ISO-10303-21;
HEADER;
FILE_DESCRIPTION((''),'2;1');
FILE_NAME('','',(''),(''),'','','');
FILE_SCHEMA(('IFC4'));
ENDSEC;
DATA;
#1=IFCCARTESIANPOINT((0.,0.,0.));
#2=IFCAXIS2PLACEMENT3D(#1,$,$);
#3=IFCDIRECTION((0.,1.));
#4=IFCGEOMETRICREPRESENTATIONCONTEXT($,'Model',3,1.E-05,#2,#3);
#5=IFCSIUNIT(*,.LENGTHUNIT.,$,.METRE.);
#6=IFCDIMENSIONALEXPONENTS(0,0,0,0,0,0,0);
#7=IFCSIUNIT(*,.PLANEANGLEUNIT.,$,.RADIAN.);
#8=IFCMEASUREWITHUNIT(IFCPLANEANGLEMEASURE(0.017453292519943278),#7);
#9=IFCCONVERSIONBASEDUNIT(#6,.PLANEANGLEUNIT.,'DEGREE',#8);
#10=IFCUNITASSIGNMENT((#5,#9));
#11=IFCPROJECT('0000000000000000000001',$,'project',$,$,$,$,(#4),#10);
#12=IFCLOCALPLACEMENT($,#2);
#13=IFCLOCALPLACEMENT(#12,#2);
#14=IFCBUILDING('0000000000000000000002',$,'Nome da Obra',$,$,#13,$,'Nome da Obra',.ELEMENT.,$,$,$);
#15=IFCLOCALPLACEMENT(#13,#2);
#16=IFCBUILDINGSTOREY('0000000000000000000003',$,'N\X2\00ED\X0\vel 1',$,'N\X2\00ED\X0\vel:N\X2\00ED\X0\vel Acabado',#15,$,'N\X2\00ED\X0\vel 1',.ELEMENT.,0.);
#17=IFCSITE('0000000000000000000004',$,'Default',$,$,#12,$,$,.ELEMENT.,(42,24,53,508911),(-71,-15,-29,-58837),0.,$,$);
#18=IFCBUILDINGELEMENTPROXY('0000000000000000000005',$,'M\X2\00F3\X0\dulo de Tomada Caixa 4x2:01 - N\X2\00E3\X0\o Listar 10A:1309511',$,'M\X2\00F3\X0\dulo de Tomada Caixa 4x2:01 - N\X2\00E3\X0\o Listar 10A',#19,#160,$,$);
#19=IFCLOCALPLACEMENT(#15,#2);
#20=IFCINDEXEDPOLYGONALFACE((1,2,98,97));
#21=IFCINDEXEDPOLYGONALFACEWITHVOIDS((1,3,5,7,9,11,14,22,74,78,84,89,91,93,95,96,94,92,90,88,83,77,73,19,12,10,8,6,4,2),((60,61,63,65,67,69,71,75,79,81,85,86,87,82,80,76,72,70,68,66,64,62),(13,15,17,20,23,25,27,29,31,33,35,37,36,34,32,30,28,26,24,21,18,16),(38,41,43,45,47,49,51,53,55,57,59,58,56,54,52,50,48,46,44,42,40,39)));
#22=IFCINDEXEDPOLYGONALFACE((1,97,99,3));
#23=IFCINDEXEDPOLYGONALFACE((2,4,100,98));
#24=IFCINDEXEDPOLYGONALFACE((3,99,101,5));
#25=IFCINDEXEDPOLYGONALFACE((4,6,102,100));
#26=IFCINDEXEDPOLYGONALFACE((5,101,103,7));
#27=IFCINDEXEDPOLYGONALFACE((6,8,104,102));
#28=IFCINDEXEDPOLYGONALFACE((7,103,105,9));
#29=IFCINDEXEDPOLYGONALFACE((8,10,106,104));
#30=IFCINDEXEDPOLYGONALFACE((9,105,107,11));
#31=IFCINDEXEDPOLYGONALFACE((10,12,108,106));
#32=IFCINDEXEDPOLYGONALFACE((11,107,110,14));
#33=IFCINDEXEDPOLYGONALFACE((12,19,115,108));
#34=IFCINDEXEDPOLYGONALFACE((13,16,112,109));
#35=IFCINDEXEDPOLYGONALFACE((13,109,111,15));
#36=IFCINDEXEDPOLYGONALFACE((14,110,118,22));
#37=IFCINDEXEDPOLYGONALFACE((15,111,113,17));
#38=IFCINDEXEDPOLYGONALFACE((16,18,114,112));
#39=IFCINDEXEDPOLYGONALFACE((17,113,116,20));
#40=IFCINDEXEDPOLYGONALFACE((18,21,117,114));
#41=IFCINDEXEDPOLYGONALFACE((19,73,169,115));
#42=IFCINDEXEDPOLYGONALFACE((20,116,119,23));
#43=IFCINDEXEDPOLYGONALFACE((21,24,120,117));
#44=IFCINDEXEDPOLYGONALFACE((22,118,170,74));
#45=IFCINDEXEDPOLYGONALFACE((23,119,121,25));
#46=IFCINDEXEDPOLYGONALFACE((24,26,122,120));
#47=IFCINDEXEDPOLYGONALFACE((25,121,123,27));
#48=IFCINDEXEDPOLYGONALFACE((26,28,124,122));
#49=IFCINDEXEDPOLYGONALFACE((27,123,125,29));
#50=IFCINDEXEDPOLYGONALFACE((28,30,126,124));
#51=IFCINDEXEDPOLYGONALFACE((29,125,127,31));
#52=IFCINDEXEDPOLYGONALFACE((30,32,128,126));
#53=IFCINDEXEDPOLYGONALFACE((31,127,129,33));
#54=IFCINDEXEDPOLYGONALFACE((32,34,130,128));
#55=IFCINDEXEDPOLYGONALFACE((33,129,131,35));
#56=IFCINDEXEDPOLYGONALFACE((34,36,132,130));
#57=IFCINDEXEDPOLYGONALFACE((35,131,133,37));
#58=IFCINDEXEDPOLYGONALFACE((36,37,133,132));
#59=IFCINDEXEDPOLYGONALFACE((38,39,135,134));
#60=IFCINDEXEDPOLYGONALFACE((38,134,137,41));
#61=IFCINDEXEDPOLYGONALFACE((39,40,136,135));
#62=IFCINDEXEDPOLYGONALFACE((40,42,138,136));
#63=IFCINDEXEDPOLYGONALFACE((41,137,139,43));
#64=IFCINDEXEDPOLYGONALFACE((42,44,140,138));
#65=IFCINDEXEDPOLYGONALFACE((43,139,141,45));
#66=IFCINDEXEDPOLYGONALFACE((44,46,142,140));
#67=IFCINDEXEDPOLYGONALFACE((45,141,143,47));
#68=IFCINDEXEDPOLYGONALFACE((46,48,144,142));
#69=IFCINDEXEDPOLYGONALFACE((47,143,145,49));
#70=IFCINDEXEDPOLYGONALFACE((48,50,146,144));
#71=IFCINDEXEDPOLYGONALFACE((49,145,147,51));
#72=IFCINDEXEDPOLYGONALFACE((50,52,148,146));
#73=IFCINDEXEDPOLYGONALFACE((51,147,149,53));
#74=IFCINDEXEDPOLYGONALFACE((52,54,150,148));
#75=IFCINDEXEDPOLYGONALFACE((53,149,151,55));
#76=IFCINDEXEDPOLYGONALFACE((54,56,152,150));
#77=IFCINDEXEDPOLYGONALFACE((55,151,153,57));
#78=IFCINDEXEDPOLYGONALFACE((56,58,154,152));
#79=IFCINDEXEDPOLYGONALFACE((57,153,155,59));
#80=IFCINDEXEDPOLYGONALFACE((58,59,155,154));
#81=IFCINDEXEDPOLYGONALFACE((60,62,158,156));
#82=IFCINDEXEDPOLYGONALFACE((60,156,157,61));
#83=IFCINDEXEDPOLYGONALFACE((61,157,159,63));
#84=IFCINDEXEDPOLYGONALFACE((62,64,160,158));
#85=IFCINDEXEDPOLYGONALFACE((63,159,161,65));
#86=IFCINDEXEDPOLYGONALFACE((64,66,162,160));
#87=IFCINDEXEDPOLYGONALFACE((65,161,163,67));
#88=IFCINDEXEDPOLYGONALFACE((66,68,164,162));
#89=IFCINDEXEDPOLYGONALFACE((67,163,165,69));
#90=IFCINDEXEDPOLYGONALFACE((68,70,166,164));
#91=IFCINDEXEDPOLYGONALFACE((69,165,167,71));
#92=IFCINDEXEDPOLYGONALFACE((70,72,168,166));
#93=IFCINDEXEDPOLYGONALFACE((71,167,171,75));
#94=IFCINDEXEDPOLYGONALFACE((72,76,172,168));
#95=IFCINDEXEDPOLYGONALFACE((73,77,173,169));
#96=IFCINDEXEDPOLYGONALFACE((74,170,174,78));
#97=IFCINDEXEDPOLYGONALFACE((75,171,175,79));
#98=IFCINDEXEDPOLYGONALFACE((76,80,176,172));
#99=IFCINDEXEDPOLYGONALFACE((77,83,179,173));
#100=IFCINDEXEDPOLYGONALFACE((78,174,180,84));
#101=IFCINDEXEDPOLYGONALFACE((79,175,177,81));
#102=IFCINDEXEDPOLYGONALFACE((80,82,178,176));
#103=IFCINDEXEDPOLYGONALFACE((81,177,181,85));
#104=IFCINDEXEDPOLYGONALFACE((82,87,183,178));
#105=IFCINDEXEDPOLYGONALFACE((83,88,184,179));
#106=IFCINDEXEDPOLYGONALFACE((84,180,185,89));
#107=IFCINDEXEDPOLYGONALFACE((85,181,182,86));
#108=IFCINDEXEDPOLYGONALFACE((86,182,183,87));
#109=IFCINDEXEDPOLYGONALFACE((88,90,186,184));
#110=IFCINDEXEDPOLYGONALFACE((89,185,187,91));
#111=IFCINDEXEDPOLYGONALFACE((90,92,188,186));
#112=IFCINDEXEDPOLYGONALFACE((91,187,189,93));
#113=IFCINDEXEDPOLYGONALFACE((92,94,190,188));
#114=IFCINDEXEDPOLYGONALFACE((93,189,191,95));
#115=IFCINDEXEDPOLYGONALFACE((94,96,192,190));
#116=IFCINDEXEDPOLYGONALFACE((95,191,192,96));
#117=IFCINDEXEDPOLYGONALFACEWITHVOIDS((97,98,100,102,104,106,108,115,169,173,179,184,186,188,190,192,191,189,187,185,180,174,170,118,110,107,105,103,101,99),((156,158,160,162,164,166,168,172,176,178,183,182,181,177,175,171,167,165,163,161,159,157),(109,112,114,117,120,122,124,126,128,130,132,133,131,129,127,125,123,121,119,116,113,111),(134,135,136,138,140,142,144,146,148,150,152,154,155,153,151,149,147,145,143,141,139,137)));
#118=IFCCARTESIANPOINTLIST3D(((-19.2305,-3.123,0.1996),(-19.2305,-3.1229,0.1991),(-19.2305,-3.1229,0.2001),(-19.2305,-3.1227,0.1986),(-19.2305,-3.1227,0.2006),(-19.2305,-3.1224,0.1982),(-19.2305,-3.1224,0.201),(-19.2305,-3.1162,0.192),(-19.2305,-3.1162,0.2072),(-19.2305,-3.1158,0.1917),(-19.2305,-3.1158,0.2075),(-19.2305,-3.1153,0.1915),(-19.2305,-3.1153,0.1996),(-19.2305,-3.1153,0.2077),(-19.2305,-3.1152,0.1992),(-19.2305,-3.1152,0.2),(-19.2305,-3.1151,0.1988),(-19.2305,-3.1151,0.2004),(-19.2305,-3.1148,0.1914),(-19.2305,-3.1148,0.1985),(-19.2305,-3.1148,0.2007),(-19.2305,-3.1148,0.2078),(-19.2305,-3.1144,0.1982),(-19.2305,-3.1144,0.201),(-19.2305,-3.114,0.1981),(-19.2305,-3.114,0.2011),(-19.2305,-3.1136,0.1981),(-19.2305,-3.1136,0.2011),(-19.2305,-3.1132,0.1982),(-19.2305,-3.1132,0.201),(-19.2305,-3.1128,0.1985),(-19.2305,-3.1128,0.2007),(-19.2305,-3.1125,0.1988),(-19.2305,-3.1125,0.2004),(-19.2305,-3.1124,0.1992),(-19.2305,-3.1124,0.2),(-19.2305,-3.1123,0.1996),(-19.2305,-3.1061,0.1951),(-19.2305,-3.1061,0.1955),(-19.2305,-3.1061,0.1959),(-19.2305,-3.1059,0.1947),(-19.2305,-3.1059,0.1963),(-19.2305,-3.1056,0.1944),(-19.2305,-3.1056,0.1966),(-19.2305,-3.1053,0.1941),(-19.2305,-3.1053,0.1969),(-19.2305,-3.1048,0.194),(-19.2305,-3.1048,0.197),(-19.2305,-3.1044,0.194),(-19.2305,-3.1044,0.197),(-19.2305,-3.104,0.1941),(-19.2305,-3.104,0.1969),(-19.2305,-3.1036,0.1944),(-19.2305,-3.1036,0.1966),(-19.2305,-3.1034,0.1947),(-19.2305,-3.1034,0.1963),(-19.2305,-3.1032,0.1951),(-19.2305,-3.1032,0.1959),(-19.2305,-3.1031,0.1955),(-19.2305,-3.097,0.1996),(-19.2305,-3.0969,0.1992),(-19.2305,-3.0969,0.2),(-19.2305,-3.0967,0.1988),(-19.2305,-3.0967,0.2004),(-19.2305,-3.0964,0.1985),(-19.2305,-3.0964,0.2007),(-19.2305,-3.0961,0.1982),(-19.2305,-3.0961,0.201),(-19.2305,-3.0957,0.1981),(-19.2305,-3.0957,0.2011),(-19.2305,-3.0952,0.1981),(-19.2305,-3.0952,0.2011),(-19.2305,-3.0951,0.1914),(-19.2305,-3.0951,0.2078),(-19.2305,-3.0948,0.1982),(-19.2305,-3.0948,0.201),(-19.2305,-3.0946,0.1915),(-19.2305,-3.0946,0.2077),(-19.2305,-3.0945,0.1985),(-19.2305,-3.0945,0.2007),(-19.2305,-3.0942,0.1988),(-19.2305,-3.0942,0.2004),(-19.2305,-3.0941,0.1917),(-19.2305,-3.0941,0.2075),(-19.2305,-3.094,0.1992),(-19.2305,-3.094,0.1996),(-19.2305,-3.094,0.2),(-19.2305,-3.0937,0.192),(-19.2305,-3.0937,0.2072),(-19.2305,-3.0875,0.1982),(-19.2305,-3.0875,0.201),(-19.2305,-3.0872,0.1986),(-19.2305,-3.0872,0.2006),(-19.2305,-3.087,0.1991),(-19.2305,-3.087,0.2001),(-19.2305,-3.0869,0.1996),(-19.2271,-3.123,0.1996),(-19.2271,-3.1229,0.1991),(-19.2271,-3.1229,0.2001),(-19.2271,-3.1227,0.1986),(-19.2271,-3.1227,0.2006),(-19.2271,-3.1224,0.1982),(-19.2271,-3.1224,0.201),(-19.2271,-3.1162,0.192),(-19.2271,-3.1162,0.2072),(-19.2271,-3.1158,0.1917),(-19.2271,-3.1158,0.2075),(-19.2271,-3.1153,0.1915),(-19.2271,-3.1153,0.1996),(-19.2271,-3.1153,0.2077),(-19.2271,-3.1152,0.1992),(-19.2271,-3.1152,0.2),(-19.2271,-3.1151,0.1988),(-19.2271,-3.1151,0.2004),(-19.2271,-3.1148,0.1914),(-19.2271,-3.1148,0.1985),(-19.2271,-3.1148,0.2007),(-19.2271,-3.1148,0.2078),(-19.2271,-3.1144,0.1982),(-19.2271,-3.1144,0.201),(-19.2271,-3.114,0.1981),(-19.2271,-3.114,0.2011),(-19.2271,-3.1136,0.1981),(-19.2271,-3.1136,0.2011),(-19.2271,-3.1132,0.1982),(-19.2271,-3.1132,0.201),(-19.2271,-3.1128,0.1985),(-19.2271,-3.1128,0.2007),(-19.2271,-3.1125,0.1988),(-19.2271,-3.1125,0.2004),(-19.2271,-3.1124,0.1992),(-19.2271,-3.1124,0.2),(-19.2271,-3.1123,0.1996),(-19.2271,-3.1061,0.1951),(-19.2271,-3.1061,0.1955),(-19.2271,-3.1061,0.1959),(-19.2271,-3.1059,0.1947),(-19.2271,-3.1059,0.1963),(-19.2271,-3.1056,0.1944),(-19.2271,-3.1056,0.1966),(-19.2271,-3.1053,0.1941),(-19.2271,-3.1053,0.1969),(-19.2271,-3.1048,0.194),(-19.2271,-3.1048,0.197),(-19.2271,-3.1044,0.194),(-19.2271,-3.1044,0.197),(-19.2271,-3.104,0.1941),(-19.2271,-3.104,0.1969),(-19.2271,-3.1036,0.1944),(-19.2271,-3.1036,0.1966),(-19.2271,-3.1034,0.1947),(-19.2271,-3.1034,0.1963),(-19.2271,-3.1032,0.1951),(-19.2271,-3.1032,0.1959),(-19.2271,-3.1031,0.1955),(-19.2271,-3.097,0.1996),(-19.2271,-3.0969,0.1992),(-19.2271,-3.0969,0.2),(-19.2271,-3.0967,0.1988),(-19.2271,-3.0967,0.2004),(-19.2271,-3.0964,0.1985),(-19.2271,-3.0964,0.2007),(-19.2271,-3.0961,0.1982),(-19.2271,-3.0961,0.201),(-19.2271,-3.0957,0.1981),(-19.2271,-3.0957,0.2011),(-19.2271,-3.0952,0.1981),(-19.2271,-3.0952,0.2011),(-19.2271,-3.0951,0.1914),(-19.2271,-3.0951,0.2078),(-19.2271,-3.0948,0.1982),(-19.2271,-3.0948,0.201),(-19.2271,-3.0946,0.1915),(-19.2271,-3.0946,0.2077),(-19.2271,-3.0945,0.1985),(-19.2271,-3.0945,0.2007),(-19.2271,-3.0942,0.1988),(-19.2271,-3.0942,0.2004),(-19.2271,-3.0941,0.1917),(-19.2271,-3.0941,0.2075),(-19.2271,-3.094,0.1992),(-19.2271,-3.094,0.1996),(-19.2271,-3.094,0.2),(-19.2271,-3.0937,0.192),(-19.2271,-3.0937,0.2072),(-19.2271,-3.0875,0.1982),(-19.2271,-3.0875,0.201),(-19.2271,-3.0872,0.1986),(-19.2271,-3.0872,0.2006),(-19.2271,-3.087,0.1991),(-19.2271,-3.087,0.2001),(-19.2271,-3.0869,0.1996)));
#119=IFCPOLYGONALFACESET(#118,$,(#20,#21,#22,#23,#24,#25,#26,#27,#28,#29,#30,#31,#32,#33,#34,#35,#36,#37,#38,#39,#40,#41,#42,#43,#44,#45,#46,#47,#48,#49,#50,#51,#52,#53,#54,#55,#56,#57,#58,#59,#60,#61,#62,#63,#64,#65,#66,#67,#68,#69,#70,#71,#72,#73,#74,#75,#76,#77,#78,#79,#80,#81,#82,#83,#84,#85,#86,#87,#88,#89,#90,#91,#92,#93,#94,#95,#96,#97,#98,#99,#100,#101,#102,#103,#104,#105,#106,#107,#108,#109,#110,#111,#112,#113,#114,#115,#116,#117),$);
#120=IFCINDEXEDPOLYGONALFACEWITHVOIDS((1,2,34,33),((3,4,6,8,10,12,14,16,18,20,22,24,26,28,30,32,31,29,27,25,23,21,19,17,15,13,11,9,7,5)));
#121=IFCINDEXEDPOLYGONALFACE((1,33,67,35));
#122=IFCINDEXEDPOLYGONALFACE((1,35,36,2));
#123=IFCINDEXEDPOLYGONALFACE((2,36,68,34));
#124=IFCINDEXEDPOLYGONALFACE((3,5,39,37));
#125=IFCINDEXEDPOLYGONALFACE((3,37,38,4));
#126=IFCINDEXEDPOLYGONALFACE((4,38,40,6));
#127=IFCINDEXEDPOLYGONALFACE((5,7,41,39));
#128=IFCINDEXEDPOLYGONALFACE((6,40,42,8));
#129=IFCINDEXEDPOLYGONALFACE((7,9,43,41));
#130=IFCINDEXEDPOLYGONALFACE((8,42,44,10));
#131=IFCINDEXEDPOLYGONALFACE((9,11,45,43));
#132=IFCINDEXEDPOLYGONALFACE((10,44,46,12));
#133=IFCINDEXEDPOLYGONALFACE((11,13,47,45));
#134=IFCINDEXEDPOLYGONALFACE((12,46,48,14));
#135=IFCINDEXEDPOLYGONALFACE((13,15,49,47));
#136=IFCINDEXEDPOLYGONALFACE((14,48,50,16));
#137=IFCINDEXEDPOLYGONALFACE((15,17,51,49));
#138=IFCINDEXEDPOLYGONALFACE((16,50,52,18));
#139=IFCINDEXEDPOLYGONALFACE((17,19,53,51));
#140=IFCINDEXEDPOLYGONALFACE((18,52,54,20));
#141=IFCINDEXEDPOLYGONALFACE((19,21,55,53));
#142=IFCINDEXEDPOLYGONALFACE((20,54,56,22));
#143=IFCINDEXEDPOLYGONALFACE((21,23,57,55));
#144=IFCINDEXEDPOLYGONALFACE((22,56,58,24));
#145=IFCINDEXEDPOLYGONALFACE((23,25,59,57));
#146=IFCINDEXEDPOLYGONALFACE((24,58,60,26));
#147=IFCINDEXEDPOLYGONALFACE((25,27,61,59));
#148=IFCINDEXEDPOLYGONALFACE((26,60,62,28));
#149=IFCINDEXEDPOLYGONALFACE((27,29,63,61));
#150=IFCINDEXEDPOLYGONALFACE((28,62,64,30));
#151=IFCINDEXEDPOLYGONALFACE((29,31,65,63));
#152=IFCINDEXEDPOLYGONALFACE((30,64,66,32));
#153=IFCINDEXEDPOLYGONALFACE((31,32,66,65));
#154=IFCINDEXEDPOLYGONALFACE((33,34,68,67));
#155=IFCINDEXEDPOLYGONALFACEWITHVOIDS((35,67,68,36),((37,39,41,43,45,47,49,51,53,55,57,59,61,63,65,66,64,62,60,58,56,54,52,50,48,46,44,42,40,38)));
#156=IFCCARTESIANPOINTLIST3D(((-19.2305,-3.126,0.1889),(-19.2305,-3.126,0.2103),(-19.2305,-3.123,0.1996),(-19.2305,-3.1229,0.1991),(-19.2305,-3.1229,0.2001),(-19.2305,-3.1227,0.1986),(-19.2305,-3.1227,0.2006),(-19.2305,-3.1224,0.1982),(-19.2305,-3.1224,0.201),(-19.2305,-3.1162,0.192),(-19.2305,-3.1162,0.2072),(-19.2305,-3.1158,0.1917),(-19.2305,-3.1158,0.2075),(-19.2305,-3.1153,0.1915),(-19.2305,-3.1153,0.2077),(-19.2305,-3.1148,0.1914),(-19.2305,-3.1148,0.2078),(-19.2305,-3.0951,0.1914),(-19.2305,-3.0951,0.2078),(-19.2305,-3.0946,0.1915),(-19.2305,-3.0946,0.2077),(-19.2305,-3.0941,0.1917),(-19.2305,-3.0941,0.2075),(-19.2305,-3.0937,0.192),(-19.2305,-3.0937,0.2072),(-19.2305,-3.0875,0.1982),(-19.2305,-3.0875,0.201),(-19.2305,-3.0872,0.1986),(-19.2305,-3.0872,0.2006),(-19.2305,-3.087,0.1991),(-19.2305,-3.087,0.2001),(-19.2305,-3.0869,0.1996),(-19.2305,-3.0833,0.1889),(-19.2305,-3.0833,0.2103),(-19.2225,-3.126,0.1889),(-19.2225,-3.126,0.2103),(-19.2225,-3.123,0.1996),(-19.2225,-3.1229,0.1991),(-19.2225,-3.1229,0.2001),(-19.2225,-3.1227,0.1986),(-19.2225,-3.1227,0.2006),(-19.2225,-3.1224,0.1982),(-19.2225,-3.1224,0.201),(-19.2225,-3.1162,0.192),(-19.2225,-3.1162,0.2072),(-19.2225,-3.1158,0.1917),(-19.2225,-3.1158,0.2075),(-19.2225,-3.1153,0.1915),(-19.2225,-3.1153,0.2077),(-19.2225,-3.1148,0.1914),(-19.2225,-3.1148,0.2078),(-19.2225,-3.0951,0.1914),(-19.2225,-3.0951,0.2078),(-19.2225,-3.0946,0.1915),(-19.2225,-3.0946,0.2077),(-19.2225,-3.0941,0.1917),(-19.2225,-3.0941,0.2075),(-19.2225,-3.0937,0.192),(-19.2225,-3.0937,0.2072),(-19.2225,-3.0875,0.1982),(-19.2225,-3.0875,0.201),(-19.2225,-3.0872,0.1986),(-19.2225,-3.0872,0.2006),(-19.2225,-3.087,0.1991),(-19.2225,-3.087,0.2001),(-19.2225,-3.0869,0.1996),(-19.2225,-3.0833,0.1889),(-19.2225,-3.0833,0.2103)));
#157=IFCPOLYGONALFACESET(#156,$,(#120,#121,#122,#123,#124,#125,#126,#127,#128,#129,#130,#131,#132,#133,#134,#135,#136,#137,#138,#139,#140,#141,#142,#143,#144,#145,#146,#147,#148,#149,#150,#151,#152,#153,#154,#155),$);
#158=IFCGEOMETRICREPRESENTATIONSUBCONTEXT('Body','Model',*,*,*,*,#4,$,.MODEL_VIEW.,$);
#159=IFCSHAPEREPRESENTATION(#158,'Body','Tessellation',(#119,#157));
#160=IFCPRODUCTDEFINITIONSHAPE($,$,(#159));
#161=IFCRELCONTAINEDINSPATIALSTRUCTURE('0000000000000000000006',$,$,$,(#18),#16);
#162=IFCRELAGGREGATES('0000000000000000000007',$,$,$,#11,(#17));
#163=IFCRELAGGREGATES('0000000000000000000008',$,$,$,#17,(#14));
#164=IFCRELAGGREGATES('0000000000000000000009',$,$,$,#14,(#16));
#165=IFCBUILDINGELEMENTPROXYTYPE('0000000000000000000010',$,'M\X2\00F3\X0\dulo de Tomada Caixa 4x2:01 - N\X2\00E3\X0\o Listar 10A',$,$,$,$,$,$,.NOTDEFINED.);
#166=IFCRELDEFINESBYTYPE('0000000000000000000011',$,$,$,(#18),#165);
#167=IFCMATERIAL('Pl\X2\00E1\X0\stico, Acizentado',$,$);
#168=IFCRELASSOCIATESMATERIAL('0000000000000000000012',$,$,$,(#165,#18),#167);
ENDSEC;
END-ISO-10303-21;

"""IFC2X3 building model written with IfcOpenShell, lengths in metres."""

from ifc_helpers import new_model, entity, si_unit, converted_unit, direction, frame, frame_2d, origin, place, context, subcontext, project, spatial, polyline, circle_curve, parameter, trimmed, segment, composite_curve, outline, extrude, source, transform, mapped, material, type_object, type_shapes, element, save


model = new_model("IFC2X3")

# Units and contexts
model_context = context("Model", 3, precision=1e-05, world=origin(), true_north=direction((0.0, 1.0)))
body_context = subcontext(model_context, "Body", "Model", "MODEL_VIEW")
ifc_project = project(units=[si_unit("LENGTHUNIT", "METRE"), converted_unit("PLANEANGLEUNIT", "DEGREE", entity("IfcPlaneAngleMeasure", 0.017453292519943278), si_unit("PLANEANGLEUNIT", "RADIAN"), dimensions=[0, 0, 0, 0, 0, 0, 0])], contexts=[model_context])

# Site, building, storey
site_placement = place(None, origin())
site = spatial("IfcSite", under=ifc_project, at=site_placement, Name="Default", CompositionType="ELEMENT", RefLatitude=(42, 24, 53, 508911), RefLongitude=(-71, -15, -29, -58837), RefElevation=0.0)
building_placement = place(site_placement, origin())
building = spatial("IfcBuilding", under=site, at=building_placement, Name="Nome da Obra", LongName="Nome da Obra", CompositionType="ELEMENT")
storey_placement = place(building_placement, origin())
storey = spatial("IfcBuildingStorey", under=building, at=storey_placement, Name="Nível 1", ObjectType="Nível:Nível Acabado", LongName="Nível 1", CompositionType="ELEMENT", Elevation=0.0)

# Building element proxy
ifc_material_1 = material(Name="Plástico, Acizentado")
building_element_proxy_type_1 = type_object("IfcBuildingElementProxyType", Name="Módulo de Tomada Caixa 4x2:01 - Não Listar 10A", PredefinedType="NOTDEFINED", material=ifc_material_1)
shared_shape_1 = source(origin(), body_context, "Body", "SweptSolid", [
    extrude(outline(composite_curve([segment(polyline([(-0.0098, -0.0082), (0.0098, -0.0082)]), True, "CONTINUOUS"), segment(trimmed(circle_curve(frame_2d((0.0098, -0.0062), x_axis=(1.0, 0.0)), 0.002), [parameter(270.0)], [parameter(315.0)], True, "PARAMETER"), True, "CONTINUOUS"), segment(polyline([(0.0112, -0.0076), (0.0174, -0.0014)]), True, "CONTINUOUS"), segment(trimmed(circle_curve(frame_2d((0.016, 0.0), x_axis=(1.0, 0.0)), 0.002), [parameter(315.0)], [parameter(45.0)], True, "PARAMETER"), True, "CONTINUOUS"), segment(polyline([(0.0174, 0.0014), (0.0112, 0.0076)]), True, "CONTINUOUS"), segment(trimmed(circle_curve(frame_2d((0.0098, 0.0062), x_axis=(1.0, 0.0)), 0.002), [parameter(45.0)], [parameter(90.0)], True, "PARAMETER"), True, "CONTINUOUS"), segment(polyline([(0.0098, 0.0082), (-0.0098, 0.0082)]), True, "CONTINUOUS"), segment(trimmed(circle_curve(frame_2d((-0.0098, 0.0062), x_axis=(1.0, 0.0)), 0.002), [parameter(90.0)], [parameter(135.0)], True, "PARAMETER"), True, "CONTINUOUS"), segment(polyline([(-0.0112, 0.0076), (-0.0174, 0.0014)]), True, "CONTINUOUS"), segment(trimmed(circle_curve(frame_2d((-0.016, 0.0), x_axis=(1.0, 0.0)), 0.002), [parameter(135.0)], [parameter(225.0)], True, "PARAMETER"), True, "CONTINUOUS"), segment(polyline([(-0.0174, -0.0014), (-0.0112, -0.0076)]), True, "CONTINUOUS"), segment(trimmed(circle_curve(frame_2d((-0.0098, -0.0062), x_axis=(1.0, 0.0)), 0.002), [parameter(225.0)], [parameter(270.0)], True, "PARAMETER"), True, "CONTINUOUS")], self_intersect=False), holes=[composite_curve([segment(trimmed(circle_curve(frame_2d((0.0089, 0.0), x_axis=(1.0, 0.0)), 0.0015), [parameter(0.0)], [parameter(180.0)], True, "PARAMETER"), False, "CONTINUOUS"), segment(trimmed(circle_curve(frame_2d((0.0089, 0.0), x_axis=(1.0, 0.0)), 0.0015), [parameter(180.0)], [parameter(0.0)], True, "PARAMETER"), False, "CONTINUOUS")], self_intersect=False), composite_curve([segment(trimmed(circle_curve(frame_2d((-0.0003, 0.0041), x_axis=(1.0, 0.0)), 0.0015), [parameter(0.0)], [parameter(180.0)], True, "PARAMETER"), False, "CONTINUOUS"), segment(trimmed(circle_curve(frame_2d((-0.0003, 0.0041), x_axis=(1.0, 0.0)), 0.0015), [parameter(180.0)], [parameter(0.0)], True, "PARAMETER"), False, "CONTINUOUS")], self_intersect=False), composite_curve([segment(trimmed(circle_curve(frame_2d((-0.0095, 0.0), x_axis=(1.0, 0.0)), 0.0015), [parameter(0.0)], [parameter(180.0)], True, "PARAMETER"), False, "CONTINUOUS"), segment(trimmed(circle_curve(frame_2d((-0.0095, 0.0), x_axis=(1.0, 0.0)), 0.0015), [parameter(180.0)], [parameter(0.0)], True, "PARAMETER"), False, "CONTINUOUS")], self_intersect=False)]), frame((0.0003, 0.0, 0.125), z_axis=(0.0, 1.0, 0.0), x_axis=(1.0, 0.0, 0.0)), (0.0, 0.0, 1.0), 0.0034),
    extrude(outline(polyline([(-0.0214, -0.0107), (0.0214, -0.0107), (0.0214, 0.0107), (-0.0214, 0.0107), (-0.0214, -0.0107)]), holes=[composite_curve([segment(polyline([(0.0101, -0.0082), (-0.0095, -0.0082)]), True, "CONTINUOUS"), segment(trimmed(circle_curve(frame_2d((-0.0095, -0.0062), x_axis=(1.0, 0.0)), 0.002), [parameter(225.0)], [parameter(270.0)], True, "PARAMETER"), False, "CONTINUOUS"), segment(polyline([(-0.0109, -0.0076), (-0.0171, -0.0014)]), True, "CONTINUOUS"), segment(trimmed(circle_curve(frame_2d((-0.0157, 0.0), x_axis=(1.0, 0.0)), 0.002), [parameter(135.0)], [parameter(225.0)], True, "PARAMETER"), False, "CONTINUOUS"), segment(polyline([(-0.0171, 0.0014), (-0.0109, 0.0076)]), True, "CONTINUOUS"), segment(trimmed(circle_curve(frame_2d((-0.0095, 0.0062), x_axis=(1.0, 0.0)), 0.002), [parameter(90.0)], [parameter(135.0)], True, "PARAMETER"), False, "CONTINUOUS"), segment(polyline([(-0.0095, 0.0082), (0.0101, 0.0082)]), True, "CONTINUOUS"), segment(trimmed(circle_curve(frame_2d((0.0101, 0.0062), x_axis=(1.0, 0.0)), 0.002), [parameter(45.0)], [parameter(90.0)], True, "PARAMETER"), False, "CONTINUOUS"), segment(polyline([(0.0115, 0.0076), (0.0177, 0.0014)]), True, "CONTINUOUS"), segment(trimmed(circle_curve(frame_2d((0.0163, 0.0), x_axis=(1.0, 0.0)), 0.002), [parameter(315.0)], [parameter(45.0)], True, "PARAMETER"), False, "CONTINUOUS"), segment(polyline([(0.0177, -0.0014), (0.0115, -0.0076)]), True, "CONTINUOUS"), segment(trimmed(circle_curve(frame_2d((0.0101, -0.0062), x_axis=(1.0, 0.0)), 0.002), [parameter(270.0)], [parameter(315.0)], True, "PARAMETER"), False, "CONTINUOUS")], self_intersect=False)]), frame((0.0, 0.0, 0.125), z_axis=(0.0, 1.0, 0.0), x_axis=(1.0, 0.0, 0.0)), (0.0, 0.0, 1.0), 0.008),
])
type_shapes(building_element_proxy_type_1, [shared_shape_1])
for number, where, z_axis, x_axis, name in (
    (1, (-19.2305, -3.1046, 0.0746), (0.0, 0.0, 1.0), (0.0, -1.0, 0.0), "Módulo de Tomada Caixa 4x2:01 - Não Listar 10A:1309511"),
):
    element("IfcBuildingElementProxy", number, at=place(storey_placement, frame(where, z_axis=z_axis, x_axis=x_axis)), inside=storey, type_object=building_element_proxy_type_1, material=ifc_material_1, Name=name, ObjectType="Módulo de Tomada Caixa 4x2:01 - Não Listar 10A", context=body_context, shape_type="MappedRepresentation", body=[
        mapped(shared_shape_1, transform((0.0, 0.0, 0.0), scale=1.0)),
    ])

save(model, "model.ifc")
